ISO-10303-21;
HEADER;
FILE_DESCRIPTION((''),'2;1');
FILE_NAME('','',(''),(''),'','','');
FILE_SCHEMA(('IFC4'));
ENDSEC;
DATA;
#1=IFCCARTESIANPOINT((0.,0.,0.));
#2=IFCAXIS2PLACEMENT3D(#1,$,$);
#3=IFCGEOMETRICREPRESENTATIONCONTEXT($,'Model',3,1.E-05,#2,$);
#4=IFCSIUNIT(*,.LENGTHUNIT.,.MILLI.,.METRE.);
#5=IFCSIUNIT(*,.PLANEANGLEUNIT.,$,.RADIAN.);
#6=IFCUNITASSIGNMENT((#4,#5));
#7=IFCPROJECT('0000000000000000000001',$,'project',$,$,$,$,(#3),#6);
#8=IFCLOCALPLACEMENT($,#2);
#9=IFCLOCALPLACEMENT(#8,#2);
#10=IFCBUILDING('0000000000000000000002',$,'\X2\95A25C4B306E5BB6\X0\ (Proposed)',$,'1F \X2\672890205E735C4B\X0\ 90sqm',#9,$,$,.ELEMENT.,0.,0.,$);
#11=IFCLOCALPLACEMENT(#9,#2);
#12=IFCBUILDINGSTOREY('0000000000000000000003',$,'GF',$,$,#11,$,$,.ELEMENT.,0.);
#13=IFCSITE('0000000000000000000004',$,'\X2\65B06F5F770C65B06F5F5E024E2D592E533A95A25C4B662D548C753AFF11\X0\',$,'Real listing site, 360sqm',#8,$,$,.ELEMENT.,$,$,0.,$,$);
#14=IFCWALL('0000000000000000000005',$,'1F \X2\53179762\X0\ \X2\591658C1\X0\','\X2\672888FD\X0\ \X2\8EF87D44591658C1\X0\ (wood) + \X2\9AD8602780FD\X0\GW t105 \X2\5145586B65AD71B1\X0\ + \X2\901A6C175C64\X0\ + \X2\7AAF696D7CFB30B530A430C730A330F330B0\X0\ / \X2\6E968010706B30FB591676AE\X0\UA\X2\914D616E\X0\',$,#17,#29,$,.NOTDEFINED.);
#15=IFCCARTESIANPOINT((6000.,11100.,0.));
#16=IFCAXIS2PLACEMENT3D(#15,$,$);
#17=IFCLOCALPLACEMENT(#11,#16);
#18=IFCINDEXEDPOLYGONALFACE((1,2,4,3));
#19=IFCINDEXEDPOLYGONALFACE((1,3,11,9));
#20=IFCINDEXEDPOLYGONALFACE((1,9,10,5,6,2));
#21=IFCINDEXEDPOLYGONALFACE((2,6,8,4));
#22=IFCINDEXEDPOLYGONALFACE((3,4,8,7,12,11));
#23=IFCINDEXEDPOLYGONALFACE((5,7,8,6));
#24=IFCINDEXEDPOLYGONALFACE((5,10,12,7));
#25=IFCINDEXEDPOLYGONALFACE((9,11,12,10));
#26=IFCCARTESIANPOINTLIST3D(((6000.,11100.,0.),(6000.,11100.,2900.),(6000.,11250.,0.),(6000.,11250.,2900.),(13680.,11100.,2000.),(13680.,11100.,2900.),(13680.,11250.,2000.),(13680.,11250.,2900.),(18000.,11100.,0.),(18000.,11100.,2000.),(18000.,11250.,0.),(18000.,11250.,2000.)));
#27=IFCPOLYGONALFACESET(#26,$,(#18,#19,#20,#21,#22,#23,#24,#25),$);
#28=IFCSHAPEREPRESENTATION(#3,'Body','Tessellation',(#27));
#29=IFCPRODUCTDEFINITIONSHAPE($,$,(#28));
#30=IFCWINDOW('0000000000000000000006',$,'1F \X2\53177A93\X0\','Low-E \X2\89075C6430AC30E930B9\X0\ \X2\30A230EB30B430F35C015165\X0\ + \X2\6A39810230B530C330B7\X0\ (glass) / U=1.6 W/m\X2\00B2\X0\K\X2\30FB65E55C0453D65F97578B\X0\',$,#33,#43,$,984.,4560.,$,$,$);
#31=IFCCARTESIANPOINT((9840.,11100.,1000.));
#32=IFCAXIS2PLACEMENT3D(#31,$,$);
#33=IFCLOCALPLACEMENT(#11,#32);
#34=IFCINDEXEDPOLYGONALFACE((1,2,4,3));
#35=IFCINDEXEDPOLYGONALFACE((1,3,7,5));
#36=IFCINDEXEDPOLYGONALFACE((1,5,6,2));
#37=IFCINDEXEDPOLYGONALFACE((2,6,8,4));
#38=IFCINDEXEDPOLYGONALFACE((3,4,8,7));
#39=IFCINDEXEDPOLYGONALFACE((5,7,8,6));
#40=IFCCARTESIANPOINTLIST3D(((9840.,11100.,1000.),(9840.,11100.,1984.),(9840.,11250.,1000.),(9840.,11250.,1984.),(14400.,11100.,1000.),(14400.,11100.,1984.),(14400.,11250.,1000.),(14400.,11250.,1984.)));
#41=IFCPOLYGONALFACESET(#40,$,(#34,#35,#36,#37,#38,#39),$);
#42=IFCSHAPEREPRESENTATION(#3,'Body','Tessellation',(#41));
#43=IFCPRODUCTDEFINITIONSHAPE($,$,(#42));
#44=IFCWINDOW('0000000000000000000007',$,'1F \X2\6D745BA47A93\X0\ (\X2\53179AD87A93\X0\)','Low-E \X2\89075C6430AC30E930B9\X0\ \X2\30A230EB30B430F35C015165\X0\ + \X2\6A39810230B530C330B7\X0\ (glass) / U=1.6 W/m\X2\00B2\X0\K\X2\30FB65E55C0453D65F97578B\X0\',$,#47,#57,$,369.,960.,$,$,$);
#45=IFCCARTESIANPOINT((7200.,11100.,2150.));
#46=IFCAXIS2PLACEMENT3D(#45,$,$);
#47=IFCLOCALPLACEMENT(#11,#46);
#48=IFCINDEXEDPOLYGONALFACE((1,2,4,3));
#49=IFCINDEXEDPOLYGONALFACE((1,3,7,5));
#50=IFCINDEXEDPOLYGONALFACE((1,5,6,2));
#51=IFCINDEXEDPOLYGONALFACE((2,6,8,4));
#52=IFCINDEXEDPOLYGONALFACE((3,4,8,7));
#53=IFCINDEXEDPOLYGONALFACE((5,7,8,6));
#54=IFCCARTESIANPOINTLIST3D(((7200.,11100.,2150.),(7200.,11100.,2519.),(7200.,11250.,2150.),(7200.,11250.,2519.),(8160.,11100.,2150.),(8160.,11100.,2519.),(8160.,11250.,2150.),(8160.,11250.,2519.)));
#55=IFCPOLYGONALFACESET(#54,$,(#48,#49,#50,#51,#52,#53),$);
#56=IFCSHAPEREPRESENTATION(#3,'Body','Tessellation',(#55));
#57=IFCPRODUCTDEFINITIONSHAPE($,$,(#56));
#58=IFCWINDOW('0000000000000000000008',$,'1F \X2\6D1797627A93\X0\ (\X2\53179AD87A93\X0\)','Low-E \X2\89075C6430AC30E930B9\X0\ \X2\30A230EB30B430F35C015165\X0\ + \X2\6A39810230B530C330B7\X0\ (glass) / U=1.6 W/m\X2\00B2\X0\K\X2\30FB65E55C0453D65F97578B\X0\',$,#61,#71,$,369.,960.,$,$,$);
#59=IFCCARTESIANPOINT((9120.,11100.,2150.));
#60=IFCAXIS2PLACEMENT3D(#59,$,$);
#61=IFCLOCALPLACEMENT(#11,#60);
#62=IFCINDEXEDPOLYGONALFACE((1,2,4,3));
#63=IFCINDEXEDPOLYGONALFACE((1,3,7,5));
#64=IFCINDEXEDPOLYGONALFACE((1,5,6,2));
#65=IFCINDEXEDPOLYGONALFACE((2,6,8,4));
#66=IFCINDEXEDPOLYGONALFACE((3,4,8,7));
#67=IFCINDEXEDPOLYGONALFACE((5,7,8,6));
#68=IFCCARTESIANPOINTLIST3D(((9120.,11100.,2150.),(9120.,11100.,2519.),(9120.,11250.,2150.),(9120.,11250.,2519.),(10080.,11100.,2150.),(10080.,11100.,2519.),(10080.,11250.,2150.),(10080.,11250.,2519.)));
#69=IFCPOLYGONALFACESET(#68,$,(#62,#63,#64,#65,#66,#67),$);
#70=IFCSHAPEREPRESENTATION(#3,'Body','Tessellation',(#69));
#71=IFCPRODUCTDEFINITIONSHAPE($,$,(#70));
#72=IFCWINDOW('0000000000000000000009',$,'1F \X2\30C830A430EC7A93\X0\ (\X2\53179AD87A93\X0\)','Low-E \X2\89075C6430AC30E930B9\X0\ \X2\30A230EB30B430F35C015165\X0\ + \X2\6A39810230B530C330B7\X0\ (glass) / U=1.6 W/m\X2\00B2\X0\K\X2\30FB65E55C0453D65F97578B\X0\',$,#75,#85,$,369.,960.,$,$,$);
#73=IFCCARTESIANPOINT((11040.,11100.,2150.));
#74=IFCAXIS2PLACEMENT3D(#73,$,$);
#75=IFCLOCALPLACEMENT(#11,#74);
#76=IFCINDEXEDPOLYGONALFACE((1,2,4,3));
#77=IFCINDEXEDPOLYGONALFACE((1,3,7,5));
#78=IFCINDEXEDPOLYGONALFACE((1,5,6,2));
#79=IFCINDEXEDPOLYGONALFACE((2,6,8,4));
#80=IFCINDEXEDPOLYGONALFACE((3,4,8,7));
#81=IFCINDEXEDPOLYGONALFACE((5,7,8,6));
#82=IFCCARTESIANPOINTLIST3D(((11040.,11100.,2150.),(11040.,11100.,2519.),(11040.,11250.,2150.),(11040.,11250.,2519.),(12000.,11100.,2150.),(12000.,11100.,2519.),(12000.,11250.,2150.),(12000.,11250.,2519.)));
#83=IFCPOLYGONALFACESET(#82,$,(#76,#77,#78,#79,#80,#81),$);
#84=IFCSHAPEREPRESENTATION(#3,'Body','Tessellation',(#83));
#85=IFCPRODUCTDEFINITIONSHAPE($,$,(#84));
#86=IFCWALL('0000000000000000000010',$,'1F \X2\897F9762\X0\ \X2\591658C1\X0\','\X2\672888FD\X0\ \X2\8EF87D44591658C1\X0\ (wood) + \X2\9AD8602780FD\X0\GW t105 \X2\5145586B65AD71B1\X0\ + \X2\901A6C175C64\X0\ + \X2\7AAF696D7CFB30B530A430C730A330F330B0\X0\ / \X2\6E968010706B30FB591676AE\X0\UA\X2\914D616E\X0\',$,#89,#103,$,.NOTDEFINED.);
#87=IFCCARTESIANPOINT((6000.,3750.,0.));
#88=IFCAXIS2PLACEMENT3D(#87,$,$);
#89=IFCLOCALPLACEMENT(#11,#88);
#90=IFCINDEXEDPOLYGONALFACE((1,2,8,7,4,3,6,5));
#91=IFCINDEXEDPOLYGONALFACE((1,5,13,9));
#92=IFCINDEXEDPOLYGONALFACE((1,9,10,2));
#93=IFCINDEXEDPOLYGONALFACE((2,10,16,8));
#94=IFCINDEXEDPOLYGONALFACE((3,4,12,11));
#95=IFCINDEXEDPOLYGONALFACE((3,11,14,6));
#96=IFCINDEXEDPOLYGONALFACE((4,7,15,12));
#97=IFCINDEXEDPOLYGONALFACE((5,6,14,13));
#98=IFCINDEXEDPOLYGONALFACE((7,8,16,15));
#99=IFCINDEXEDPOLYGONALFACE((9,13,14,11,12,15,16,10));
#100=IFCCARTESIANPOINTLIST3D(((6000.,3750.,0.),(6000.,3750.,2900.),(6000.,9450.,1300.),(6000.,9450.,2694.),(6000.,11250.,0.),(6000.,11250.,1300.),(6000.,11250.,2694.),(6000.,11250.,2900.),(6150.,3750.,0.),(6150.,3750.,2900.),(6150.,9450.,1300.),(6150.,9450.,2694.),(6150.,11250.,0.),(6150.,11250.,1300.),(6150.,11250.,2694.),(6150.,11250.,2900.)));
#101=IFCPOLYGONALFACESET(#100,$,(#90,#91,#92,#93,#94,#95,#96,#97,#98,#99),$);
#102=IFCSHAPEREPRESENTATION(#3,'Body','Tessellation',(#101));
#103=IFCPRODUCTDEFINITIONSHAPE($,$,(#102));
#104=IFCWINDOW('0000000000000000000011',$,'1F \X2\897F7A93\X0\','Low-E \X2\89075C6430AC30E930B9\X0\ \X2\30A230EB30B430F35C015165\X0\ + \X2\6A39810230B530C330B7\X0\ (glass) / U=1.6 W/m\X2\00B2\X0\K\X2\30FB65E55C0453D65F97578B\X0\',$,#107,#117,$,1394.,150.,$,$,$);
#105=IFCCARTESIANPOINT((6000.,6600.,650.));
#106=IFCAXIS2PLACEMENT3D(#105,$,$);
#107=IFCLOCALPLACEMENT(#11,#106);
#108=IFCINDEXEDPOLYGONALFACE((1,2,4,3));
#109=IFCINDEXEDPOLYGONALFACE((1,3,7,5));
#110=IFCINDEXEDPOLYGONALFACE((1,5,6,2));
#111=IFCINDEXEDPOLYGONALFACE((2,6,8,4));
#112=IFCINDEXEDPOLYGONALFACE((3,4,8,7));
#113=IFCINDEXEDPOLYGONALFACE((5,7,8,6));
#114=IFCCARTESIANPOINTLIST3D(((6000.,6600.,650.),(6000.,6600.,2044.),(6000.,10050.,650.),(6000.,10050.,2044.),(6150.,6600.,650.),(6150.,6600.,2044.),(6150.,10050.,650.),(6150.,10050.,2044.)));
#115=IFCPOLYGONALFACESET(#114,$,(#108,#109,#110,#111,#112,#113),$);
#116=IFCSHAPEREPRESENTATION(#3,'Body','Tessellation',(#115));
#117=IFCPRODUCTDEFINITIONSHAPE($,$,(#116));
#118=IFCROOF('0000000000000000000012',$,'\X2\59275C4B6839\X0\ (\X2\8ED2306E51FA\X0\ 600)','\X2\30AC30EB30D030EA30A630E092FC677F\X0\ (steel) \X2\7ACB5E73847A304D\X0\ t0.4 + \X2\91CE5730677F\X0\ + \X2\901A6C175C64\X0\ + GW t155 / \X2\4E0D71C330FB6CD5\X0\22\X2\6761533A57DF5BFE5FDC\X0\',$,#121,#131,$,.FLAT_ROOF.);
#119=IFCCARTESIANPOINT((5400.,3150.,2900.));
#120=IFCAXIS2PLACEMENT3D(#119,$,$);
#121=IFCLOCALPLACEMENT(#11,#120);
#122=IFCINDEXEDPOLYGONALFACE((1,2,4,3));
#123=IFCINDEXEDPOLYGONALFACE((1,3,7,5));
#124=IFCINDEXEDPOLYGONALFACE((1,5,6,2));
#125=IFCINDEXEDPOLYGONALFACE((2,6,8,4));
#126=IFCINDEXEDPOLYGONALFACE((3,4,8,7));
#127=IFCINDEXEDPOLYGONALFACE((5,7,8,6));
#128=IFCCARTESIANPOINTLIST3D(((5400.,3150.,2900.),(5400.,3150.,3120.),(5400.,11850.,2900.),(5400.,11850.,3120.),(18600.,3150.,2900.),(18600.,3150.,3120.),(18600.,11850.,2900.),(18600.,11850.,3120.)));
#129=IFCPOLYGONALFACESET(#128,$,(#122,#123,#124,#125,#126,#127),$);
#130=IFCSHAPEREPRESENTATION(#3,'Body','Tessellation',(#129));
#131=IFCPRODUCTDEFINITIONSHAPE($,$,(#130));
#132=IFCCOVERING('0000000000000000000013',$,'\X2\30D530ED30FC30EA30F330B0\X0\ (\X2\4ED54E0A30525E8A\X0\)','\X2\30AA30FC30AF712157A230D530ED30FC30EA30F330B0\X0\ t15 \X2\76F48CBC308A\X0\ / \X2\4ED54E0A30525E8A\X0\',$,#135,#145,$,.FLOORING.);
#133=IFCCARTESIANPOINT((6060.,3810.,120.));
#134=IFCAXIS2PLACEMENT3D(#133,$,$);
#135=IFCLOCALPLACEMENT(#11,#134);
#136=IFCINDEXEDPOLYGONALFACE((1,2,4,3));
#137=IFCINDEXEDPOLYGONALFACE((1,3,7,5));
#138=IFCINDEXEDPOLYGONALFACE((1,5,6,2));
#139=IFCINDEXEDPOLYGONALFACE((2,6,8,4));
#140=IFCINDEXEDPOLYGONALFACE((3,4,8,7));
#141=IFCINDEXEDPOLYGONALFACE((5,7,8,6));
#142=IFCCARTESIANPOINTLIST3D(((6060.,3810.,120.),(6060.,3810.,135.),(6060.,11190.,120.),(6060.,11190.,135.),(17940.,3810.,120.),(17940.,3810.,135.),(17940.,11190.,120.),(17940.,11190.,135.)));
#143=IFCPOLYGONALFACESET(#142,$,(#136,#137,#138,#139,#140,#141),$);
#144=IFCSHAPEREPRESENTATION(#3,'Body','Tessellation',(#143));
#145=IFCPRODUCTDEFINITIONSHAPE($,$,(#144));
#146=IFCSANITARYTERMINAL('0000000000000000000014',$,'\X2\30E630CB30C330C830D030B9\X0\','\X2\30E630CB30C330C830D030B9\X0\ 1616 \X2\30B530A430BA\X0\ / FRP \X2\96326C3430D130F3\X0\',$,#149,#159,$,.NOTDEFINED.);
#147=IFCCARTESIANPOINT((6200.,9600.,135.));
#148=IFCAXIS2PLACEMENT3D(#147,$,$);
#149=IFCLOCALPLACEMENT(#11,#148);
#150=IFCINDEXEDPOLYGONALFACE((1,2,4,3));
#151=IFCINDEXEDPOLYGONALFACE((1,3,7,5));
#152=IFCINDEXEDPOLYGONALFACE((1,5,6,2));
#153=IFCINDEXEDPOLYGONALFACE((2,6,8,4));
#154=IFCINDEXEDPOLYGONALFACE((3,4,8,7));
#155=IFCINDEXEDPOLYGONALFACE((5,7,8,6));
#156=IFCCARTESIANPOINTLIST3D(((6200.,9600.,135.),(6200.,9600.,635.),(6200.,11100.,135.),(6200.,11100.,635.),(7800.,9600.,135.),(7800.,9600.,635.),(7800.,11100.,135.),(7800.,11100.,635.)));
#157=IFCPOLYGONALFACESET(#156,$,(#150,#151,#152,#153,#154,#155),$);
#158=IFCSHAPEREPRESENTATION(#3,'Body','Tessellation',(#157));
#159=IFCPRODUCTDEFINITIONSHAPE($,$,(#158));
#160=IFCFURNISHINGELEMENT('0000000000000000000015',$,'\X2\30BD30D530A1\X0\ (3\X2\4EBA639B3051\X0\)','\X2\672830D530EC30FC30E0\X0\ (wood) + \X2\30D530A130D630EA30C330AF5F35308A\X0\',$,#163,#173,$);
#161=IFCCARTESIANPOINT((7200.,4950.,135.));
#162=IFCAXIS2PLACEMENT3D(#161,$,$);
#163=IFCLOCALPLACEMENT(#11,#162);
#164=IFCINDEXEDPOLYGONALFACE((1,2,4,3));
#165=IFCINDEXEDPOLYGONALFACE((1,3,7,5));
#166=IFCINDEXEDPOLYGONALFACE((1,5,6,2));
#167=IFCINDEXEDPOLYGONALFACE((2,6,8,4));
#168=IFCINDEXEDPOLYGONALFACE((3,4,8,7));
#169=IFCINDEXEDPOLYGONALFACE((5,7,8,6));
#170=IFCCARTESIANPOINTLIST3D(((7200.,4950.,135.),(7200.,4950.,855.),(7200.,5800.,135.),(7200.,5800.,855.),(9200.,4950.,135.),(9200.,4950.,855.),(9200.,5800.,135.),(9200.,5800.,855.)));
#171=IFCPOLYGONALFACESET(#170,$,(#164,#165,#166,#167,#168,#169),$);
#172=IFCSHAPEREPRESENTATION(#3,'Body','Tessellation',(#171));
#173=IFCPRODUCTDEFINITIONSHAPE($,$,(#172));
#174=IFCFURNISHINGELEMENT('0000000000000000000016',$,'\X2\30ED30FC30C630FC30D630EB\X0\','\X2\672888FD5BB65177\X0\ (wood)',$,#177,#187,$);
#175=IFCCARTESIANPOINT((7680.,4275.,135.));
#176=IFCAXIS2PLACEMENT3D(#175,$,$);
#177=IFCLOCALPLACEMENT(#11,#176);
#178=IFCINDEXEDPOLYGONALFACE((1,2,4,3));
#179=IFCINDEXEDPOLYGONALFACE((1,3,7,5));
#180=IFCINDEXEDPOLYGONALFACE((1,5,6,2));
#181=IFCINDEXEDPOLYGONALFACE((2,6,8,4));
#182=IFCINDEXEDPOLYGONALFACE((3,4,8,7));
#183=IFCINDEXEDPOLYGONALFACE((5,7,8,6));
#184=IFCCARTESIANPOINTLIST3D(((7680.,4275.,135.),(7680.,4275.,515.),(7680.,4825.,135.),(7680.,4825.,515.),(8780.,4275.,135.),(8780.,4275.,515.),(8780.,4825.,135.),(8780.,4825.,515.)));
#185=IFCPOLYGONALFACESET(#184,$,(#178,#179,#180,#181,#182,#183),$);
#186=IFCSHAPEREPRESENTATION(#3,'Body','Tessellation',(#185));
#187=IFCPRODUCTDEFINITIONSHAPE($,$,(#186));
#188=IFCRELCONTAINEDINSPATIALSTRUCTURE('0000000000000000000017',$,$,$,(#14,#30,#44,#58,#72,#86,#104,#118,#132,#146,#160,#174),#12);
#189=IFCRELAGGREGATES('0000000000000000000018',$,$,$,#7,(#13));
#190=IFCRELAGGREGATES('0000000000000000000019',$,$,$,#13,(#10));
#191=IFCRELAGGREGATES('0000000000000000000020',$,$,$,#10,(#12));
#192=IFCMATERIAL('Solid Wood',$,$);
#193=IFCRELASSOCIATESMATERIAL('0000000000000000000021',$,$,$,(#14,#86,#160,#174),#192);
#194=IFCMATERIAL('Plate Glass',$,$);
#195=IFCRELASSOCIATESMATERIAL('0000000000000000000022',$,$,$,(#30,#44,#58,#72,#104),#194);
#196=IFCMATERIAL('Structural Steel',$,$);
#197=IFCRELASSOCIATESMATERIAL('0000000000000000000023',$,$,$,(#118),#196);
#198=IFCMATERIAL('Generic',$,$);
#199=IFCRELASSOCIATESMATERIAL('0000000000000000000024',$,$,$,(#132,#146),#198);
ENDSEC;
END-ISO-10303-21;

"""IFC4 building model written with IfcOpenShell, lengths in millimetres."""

from ifc_helpers import new_model, si_unit, frame, frame_2d, origin, place, context, project, spatial, rectangle, extrude, material, element, fill, save


model = new_model("IFC4")

# Units and contexts
model_context = context("Model", 3, precision=1e-05, world=origin())
ifc_project = project(units=[si_unit("LENGTHUNIT", "METRE", prefix="MILLI"), si_unit("PLANEANGLEUNIT", "RADIAN")], contexts=[model_context])

# Site, building, storey
site_placement = place(None, origin())
site = spatial("IfcSite", under=ifc_project, at=site_placement, Name="新潟県新潟市中央区関屋昭和町１", ObjectType="Real listing site, 360sqm", CompositionType="ELEMENT", RefElevation=0.0)
building_placement = place(site_placement, origin())
building = spatial("IfcBuilding", under=site, at=building_placement, Name="関屋の家 (Proposed)", ObjectType="1F 木造平屋 90sqm", CompositionType="ELEMENT", ElevationOfRefHeight=0.0, ElevationOfTerrain=0.0)
storey_placement = place(building_placement, origin())
storey = spatial("IfcBuildingStorey", under=building, at=storey_placement, Name="GF", CompositionType="ELEMENT", Elevation=0.0)

# Shared definitions
ifc_material_1 = material(Name="Solid Wood")

# Shared definitions
ifc_material_2 = material(Name="Plate Glass")

# Wall, openings, windows
wall_1_placement = place(storey_placement, frame((6000.0, 11100.0, 0.0)))
wall_1 = element("IfcWall", 1, at=wall_1_placement, inside=storey, material=ifc_material_1, Name="1F 北面 外壁", Description="木製 軸組外壁 (wood) + 高性能GW t105 充填断熱 + 通気層 + 窯業系サイディング / 準耐火・外皮UA配慮", PredefinedType="NOTDEFINED", context=model_context, shape_type="SweptSolid", body=[
    extrude(rectangle(XDim=12000.0, YDim=150.0, at=frame_2d((6000.0, 75.0))), frame((6000.0, 11100.0, 0.0)), (0.0, 0.0, 1.0), 2900.0),
])
opening_1_placement = place(storey_placement, frame((9840.0, 11100.0, 1000.0)))
opening_1 = element("IfcOpeningElement", 2, at=opening_1_placement, cuts=wall_1, PredefinedType="NOTDEFINED", context=model_context, shape_type="SweptSolid", body=[
    extrude(rectangle(XDim=4560.0, YDim=150.0, at=frame_2d((2280.0, 75.0))), frame((9840.0, 11100.0, 1000.0)), (0.0, 0.0, 1.0), 984.0),
])
opening_2_placement = place(storey_placement, frame((7200.0, 11100.0, 2150.0)))
opening_2 = element("IfcOpeningElement", 3, at=opening_2_placement, cuts=wall_1, PredefinedType="NOTDEFINED", context=model_context, shape_type="SweptSolid", body=[
    extrude(rectangle(XDim=960.0, YDim=150.0, at=frame_2d((480.0, 75.0))), frame((7200.0, 11100.0, 2150.0)), (0.0, 0.0, 1.0), 369.0),
])
opening_3_placement = place(storey_placement, frame((9120.0, 11100.0, 2150.0)))
opening_3 = element("IfcOpeningElement", 4, at=opening_3_placement, cuts=wall_1, PredefinedType="NOTDEFINED", context=model_context, shape_type="SweptSolid", body=[
    extrude(rectangle(XDim=960.0, YDim=150.0, at=frame_2d((480.0, 75.0))), frame((9120.0, 11100.0, 2150.0)), (0.0, 0.0, 1.0), 369.0),
])
opening_4_placement = place(storey_placement, frame((11040.0, 11100.0, 2150.0)))
opening_4 = element("IfcOpeningElement", 5, at=opening_4_placement, cuts=wall_1, PredefinedType="NOTDEFINED", context=model_context, shape_type="SweptSolid", body=[
    extrude(rectangle(XDim=960.0, YDim=150.0, at=frame_2d((480.0, 75.0))), frame((11040.0, 11100.0, 2150.0)), (0.0, 0.0, 1.0), 369.0),
])
window_1_placement = place(storey_placement, frame((9840.0, 11100.0, 1000.0)))
window_1 = element("IfcWindow", 6, at=window_1_placement, inside=storey, material=ifc_material_2, Name="1F 北窓", Description="Low-E 複層ガラス アルゴン封入 + 樹脂サッシ (glass) / U=1.6 W/m²K・日射取得型", OverallHeight=984.0, OverallWidth=4560.0, context=model_context, shape_type="SweptSolid", body=[
    extrude(rectangle(XDim=4560.0, YDim=150.0, at=frame_2d((2280.0, 75.0))), frame((9840.0, 11100.0, 1000.0)), (0.0, 0.0, 1.0), 984.0),
])
fill(opening_1, window_1)
window_2_placement = place(storey_placement, frame((7200.0, 11100.0, 2150.0)))
window_2 = element("IfcWindow", 7, at=window_2_placement, inside=storey, material=ifc_material_2, Name="1F 浴室窓 (北高窓)", Description="Low-E 複層ガラス アルゴン封入 + 樹脂サッシ (glass) / U=1.6 W/m²K・日射取得型", OverallHeight=369.0, OverallWidth=960.0, context=model_context, shape_type="SweptSolid", body=[
    extrude(rectangle(XDim=960.0, YDim=150.0, at=frame_2d((480.0, 75.0))), frame((7200.0, 11100.0, 2150.0)), (0.0, 0.0, 1.0), 369.0),
])
fill(opening_2, window_2)
window_3_placement = place(storey_placement, frame((9120.0, 11100.0, 2150.0)))
window_3 = element("IfcWindow", 8, at=window_3_placement, inside=storey, material=ifc_material_2, Name="1F 洗面窓 (北高窓)", Description="Low-E 複層ガラス アルゴン封入 + 樹脂サッシ (glass) / U=1.6 W/m²K・日射取得型", OverallHeight=369.0, OverallWidth=960.0, context=model_context, shape_type="SweptSolid", body=[
    extrude(rectangle(XDim=960.0, YDim=150.0, at=frame_2d((480.0, 75.0))), frame((9120.0, 11100.0, 2150.0)), (0.0, 0.0, 1.0), 369.0),
])
fill(opening_3, window_3)
window_4_placement = place(storey_placement, frame((11040.0, 11100.0, 2150.0)))
window_4 = element("IfcWindow", 9, at=window_4_placement, inside=storey, material=ifc_material_2, Name="1F トイレ窓 (北高窓)", Description="Low-E 複層ガラス アルゴン封入 + 樹脂サッシ (glass) / U=1.6 W/m²K・日射取得型", OverallHeight=369.0, OverallWidth=960.0, context=model_context, shape_type="SweptSolid", body=[
    extrude(rectangle(XDim=960.0, YDim=150.0, at=frame_2d((480.0, 75.0))), frame((11040.0, 11100.0, 2150.0)), (0.0, 0.0, 1.0), 369.0),
])
fill(opening_4, window_4)

# Wall, opening, window
wall_2_placement = place(storey_placement, frame((6000.0, 3750.0, 0.0)))
wall_2 = element("IfcWall", 10, at=wall_2_placement, inside=storey, material=ifc_material_1, Name="1F 西面 外壁", Description="木製 軸組外壁 (wood) + 高性能GW t105 充填断熱 + 通気層 + 窯業系サイディング / 準耐火・外皮UA配慮", PredefinedType="NOTDEFINED", context=model_context, shape_type="SweptSolid", body=[
    extrude(rectangle(XDim=150.0, YDim=7500.0, at=frame_2d((75.0, 3750.0))), frame((6000.0, 3750.0, 0.0)), (0.0, 0.0, 1.0), 2900.0),
])
opening_5_placement = place(storey_placement, frame((6000.0, 6600.0, 650.0)))
opening_5 = element("IfcOpeningElement", 11, at=opening_5_placement, cuts=wall_2, PredefinedType="NOTDEFINED", context=model_context, shape_type="SweptSolid", body=[
    extrude(rectangle(XDim=150.0, YDim=3450.0, at=frame_2d((75.0, 1725.0))), frame((6000.0, 6600.0, 650.0)), (0.0, 0.0, 1.0), 1394.0),
])
window_5_placement = place(storey_placement, frame((6000.0, 6600.0, 650.0)))
window_5 = element("IfcWindow", 12, at=window_5_placement, inside=storey, material=ifc_material_2, Name="1F 西窓", Description="Low-E 複層ガラス アルゴン封入 + 樹脂サッシ (glass) / U=1.6 W/m²K・日射取得型", OverallHeight=1394.0, OverallWidth=150.0, context=model_context, shape_type="SweptSolid", body=[
    extrude(rectangle(XDim=150.0, YDim=3450.0, at=frame_2d((75.0, 1725.0))), frame((6000.0, 6600.0, 650.0)), (0.0, 0.0, 1.0), 1394.0),
])
fill(opening_5, window_5)

# Roof
ifc_material_3 = material(Name="Structural Steel")
roof_placement = place(storey_placement, frame((5400.0, 3150.0, 2900.0)))
element("IfcRoof", 13, at=roof_placement, inside=storey, material=ifc_material_3, Name="大屋根 (軒の出 600)", Description="ガルバリウム鋼板 (steel) 立平葺き t0.4 + 野地板 + 通気層 + GW t155 / 不燃・法22条区域対応", PredefinedType="FLAT_ROOF", context=model_context, shape_type="SweptSolid", body=[
    extrude(rectangle(XDim=13200.0, YDim=8700.0, at=frame_2d((6600.0, 4350.0))), frame((5400.0, 3150.0, 2900.0)), (0.0, 0.0, 1.0), 220.0),
])

# Covering
ifc_material_4 = material(Name="Generic")
covering_placement = place(storey_placement, frame((6060.0, 3810.0, 120.0)))
element("IfcCovering", 14, at=covering_placement, inside=storey, material=ifc_material_4, Name="フローリング (仕上げ床)", Description="オーク無垢フローリング t15 直貼り / 仕上げ床", PredefinedType="FLOORING", context=model_context, shape_type="SweptSolid", body=[
    extrude(rectangle(XDim=11880.0, YDim=7380.0, at=frame_2d((5940.0, 3690.0))), frame((6060.0, 3810.0, 120.0)), (0.0, 0.0, 1.0), 15.0),
])

# Sanitary terminal
sanitary_terminal_placement = place(storey_placement, frame((6200.0, 9600.0, 135.0)))
element("IfcSanitaryTerminal", 15, at=sanitary_terminal_placement, inside=storey, material=ifc_material_4, Name="ユニットバス", Description="ユニットバス 1616 サイズ / FRP 防水パン", PredefinedType="NOTDEFINED", context=model_context, shape_type="SweptSolid", body=[
    extrude(rectangle(XDim=1600.0, YDim=1500.0, at=frame_2d((800.0, 750.0))), frame((6200.0, 9600.0, 135.0)), (0.0, 0.0, 1.0), 500.0),
])

# Furnishing elements
furnishing_1_placement = place(storey_placement, frame((7200.0, 4950.0, 135.0)))
element("IfcFurnishingElement", 16, at=furnishing_1_placement, inside=storey, material=ifc_material_1, Name="ソファ (3人掛け)", Description="木フレーム (wood) + ファブリック張り", context=model_context, shape_type="SweptSolid", body=[
    extrude(rectangle(XDim=2000.0, YDim=850.0, at=frame_2d((1000.0, 425.0))), frame((7200.0, 4950.0, 135.0)), (0.0, 0.0, 1.0), 720.0),
])
furnishing_2_placement = place(storey_placement, frame((7680.0, 4275.0, 135.0)))
element("IfcFurnishingElement", 17, at=furnishing_2_placement, inside=storey, material=ifc_material_1, Name="ローテーブル", Description="木製家具 (wood)", context=model_context, shape_type="SweptSolid", body=[
    extrude(rectangle(XDim=1100.0, YDim=550.0, at=frame_2d((550.0, 275.0))), frame((7680.0, 4275.0, 135.0)), (0.0, 0.0, 1.0), 380.0),
])

save(model, "model.ifc")
